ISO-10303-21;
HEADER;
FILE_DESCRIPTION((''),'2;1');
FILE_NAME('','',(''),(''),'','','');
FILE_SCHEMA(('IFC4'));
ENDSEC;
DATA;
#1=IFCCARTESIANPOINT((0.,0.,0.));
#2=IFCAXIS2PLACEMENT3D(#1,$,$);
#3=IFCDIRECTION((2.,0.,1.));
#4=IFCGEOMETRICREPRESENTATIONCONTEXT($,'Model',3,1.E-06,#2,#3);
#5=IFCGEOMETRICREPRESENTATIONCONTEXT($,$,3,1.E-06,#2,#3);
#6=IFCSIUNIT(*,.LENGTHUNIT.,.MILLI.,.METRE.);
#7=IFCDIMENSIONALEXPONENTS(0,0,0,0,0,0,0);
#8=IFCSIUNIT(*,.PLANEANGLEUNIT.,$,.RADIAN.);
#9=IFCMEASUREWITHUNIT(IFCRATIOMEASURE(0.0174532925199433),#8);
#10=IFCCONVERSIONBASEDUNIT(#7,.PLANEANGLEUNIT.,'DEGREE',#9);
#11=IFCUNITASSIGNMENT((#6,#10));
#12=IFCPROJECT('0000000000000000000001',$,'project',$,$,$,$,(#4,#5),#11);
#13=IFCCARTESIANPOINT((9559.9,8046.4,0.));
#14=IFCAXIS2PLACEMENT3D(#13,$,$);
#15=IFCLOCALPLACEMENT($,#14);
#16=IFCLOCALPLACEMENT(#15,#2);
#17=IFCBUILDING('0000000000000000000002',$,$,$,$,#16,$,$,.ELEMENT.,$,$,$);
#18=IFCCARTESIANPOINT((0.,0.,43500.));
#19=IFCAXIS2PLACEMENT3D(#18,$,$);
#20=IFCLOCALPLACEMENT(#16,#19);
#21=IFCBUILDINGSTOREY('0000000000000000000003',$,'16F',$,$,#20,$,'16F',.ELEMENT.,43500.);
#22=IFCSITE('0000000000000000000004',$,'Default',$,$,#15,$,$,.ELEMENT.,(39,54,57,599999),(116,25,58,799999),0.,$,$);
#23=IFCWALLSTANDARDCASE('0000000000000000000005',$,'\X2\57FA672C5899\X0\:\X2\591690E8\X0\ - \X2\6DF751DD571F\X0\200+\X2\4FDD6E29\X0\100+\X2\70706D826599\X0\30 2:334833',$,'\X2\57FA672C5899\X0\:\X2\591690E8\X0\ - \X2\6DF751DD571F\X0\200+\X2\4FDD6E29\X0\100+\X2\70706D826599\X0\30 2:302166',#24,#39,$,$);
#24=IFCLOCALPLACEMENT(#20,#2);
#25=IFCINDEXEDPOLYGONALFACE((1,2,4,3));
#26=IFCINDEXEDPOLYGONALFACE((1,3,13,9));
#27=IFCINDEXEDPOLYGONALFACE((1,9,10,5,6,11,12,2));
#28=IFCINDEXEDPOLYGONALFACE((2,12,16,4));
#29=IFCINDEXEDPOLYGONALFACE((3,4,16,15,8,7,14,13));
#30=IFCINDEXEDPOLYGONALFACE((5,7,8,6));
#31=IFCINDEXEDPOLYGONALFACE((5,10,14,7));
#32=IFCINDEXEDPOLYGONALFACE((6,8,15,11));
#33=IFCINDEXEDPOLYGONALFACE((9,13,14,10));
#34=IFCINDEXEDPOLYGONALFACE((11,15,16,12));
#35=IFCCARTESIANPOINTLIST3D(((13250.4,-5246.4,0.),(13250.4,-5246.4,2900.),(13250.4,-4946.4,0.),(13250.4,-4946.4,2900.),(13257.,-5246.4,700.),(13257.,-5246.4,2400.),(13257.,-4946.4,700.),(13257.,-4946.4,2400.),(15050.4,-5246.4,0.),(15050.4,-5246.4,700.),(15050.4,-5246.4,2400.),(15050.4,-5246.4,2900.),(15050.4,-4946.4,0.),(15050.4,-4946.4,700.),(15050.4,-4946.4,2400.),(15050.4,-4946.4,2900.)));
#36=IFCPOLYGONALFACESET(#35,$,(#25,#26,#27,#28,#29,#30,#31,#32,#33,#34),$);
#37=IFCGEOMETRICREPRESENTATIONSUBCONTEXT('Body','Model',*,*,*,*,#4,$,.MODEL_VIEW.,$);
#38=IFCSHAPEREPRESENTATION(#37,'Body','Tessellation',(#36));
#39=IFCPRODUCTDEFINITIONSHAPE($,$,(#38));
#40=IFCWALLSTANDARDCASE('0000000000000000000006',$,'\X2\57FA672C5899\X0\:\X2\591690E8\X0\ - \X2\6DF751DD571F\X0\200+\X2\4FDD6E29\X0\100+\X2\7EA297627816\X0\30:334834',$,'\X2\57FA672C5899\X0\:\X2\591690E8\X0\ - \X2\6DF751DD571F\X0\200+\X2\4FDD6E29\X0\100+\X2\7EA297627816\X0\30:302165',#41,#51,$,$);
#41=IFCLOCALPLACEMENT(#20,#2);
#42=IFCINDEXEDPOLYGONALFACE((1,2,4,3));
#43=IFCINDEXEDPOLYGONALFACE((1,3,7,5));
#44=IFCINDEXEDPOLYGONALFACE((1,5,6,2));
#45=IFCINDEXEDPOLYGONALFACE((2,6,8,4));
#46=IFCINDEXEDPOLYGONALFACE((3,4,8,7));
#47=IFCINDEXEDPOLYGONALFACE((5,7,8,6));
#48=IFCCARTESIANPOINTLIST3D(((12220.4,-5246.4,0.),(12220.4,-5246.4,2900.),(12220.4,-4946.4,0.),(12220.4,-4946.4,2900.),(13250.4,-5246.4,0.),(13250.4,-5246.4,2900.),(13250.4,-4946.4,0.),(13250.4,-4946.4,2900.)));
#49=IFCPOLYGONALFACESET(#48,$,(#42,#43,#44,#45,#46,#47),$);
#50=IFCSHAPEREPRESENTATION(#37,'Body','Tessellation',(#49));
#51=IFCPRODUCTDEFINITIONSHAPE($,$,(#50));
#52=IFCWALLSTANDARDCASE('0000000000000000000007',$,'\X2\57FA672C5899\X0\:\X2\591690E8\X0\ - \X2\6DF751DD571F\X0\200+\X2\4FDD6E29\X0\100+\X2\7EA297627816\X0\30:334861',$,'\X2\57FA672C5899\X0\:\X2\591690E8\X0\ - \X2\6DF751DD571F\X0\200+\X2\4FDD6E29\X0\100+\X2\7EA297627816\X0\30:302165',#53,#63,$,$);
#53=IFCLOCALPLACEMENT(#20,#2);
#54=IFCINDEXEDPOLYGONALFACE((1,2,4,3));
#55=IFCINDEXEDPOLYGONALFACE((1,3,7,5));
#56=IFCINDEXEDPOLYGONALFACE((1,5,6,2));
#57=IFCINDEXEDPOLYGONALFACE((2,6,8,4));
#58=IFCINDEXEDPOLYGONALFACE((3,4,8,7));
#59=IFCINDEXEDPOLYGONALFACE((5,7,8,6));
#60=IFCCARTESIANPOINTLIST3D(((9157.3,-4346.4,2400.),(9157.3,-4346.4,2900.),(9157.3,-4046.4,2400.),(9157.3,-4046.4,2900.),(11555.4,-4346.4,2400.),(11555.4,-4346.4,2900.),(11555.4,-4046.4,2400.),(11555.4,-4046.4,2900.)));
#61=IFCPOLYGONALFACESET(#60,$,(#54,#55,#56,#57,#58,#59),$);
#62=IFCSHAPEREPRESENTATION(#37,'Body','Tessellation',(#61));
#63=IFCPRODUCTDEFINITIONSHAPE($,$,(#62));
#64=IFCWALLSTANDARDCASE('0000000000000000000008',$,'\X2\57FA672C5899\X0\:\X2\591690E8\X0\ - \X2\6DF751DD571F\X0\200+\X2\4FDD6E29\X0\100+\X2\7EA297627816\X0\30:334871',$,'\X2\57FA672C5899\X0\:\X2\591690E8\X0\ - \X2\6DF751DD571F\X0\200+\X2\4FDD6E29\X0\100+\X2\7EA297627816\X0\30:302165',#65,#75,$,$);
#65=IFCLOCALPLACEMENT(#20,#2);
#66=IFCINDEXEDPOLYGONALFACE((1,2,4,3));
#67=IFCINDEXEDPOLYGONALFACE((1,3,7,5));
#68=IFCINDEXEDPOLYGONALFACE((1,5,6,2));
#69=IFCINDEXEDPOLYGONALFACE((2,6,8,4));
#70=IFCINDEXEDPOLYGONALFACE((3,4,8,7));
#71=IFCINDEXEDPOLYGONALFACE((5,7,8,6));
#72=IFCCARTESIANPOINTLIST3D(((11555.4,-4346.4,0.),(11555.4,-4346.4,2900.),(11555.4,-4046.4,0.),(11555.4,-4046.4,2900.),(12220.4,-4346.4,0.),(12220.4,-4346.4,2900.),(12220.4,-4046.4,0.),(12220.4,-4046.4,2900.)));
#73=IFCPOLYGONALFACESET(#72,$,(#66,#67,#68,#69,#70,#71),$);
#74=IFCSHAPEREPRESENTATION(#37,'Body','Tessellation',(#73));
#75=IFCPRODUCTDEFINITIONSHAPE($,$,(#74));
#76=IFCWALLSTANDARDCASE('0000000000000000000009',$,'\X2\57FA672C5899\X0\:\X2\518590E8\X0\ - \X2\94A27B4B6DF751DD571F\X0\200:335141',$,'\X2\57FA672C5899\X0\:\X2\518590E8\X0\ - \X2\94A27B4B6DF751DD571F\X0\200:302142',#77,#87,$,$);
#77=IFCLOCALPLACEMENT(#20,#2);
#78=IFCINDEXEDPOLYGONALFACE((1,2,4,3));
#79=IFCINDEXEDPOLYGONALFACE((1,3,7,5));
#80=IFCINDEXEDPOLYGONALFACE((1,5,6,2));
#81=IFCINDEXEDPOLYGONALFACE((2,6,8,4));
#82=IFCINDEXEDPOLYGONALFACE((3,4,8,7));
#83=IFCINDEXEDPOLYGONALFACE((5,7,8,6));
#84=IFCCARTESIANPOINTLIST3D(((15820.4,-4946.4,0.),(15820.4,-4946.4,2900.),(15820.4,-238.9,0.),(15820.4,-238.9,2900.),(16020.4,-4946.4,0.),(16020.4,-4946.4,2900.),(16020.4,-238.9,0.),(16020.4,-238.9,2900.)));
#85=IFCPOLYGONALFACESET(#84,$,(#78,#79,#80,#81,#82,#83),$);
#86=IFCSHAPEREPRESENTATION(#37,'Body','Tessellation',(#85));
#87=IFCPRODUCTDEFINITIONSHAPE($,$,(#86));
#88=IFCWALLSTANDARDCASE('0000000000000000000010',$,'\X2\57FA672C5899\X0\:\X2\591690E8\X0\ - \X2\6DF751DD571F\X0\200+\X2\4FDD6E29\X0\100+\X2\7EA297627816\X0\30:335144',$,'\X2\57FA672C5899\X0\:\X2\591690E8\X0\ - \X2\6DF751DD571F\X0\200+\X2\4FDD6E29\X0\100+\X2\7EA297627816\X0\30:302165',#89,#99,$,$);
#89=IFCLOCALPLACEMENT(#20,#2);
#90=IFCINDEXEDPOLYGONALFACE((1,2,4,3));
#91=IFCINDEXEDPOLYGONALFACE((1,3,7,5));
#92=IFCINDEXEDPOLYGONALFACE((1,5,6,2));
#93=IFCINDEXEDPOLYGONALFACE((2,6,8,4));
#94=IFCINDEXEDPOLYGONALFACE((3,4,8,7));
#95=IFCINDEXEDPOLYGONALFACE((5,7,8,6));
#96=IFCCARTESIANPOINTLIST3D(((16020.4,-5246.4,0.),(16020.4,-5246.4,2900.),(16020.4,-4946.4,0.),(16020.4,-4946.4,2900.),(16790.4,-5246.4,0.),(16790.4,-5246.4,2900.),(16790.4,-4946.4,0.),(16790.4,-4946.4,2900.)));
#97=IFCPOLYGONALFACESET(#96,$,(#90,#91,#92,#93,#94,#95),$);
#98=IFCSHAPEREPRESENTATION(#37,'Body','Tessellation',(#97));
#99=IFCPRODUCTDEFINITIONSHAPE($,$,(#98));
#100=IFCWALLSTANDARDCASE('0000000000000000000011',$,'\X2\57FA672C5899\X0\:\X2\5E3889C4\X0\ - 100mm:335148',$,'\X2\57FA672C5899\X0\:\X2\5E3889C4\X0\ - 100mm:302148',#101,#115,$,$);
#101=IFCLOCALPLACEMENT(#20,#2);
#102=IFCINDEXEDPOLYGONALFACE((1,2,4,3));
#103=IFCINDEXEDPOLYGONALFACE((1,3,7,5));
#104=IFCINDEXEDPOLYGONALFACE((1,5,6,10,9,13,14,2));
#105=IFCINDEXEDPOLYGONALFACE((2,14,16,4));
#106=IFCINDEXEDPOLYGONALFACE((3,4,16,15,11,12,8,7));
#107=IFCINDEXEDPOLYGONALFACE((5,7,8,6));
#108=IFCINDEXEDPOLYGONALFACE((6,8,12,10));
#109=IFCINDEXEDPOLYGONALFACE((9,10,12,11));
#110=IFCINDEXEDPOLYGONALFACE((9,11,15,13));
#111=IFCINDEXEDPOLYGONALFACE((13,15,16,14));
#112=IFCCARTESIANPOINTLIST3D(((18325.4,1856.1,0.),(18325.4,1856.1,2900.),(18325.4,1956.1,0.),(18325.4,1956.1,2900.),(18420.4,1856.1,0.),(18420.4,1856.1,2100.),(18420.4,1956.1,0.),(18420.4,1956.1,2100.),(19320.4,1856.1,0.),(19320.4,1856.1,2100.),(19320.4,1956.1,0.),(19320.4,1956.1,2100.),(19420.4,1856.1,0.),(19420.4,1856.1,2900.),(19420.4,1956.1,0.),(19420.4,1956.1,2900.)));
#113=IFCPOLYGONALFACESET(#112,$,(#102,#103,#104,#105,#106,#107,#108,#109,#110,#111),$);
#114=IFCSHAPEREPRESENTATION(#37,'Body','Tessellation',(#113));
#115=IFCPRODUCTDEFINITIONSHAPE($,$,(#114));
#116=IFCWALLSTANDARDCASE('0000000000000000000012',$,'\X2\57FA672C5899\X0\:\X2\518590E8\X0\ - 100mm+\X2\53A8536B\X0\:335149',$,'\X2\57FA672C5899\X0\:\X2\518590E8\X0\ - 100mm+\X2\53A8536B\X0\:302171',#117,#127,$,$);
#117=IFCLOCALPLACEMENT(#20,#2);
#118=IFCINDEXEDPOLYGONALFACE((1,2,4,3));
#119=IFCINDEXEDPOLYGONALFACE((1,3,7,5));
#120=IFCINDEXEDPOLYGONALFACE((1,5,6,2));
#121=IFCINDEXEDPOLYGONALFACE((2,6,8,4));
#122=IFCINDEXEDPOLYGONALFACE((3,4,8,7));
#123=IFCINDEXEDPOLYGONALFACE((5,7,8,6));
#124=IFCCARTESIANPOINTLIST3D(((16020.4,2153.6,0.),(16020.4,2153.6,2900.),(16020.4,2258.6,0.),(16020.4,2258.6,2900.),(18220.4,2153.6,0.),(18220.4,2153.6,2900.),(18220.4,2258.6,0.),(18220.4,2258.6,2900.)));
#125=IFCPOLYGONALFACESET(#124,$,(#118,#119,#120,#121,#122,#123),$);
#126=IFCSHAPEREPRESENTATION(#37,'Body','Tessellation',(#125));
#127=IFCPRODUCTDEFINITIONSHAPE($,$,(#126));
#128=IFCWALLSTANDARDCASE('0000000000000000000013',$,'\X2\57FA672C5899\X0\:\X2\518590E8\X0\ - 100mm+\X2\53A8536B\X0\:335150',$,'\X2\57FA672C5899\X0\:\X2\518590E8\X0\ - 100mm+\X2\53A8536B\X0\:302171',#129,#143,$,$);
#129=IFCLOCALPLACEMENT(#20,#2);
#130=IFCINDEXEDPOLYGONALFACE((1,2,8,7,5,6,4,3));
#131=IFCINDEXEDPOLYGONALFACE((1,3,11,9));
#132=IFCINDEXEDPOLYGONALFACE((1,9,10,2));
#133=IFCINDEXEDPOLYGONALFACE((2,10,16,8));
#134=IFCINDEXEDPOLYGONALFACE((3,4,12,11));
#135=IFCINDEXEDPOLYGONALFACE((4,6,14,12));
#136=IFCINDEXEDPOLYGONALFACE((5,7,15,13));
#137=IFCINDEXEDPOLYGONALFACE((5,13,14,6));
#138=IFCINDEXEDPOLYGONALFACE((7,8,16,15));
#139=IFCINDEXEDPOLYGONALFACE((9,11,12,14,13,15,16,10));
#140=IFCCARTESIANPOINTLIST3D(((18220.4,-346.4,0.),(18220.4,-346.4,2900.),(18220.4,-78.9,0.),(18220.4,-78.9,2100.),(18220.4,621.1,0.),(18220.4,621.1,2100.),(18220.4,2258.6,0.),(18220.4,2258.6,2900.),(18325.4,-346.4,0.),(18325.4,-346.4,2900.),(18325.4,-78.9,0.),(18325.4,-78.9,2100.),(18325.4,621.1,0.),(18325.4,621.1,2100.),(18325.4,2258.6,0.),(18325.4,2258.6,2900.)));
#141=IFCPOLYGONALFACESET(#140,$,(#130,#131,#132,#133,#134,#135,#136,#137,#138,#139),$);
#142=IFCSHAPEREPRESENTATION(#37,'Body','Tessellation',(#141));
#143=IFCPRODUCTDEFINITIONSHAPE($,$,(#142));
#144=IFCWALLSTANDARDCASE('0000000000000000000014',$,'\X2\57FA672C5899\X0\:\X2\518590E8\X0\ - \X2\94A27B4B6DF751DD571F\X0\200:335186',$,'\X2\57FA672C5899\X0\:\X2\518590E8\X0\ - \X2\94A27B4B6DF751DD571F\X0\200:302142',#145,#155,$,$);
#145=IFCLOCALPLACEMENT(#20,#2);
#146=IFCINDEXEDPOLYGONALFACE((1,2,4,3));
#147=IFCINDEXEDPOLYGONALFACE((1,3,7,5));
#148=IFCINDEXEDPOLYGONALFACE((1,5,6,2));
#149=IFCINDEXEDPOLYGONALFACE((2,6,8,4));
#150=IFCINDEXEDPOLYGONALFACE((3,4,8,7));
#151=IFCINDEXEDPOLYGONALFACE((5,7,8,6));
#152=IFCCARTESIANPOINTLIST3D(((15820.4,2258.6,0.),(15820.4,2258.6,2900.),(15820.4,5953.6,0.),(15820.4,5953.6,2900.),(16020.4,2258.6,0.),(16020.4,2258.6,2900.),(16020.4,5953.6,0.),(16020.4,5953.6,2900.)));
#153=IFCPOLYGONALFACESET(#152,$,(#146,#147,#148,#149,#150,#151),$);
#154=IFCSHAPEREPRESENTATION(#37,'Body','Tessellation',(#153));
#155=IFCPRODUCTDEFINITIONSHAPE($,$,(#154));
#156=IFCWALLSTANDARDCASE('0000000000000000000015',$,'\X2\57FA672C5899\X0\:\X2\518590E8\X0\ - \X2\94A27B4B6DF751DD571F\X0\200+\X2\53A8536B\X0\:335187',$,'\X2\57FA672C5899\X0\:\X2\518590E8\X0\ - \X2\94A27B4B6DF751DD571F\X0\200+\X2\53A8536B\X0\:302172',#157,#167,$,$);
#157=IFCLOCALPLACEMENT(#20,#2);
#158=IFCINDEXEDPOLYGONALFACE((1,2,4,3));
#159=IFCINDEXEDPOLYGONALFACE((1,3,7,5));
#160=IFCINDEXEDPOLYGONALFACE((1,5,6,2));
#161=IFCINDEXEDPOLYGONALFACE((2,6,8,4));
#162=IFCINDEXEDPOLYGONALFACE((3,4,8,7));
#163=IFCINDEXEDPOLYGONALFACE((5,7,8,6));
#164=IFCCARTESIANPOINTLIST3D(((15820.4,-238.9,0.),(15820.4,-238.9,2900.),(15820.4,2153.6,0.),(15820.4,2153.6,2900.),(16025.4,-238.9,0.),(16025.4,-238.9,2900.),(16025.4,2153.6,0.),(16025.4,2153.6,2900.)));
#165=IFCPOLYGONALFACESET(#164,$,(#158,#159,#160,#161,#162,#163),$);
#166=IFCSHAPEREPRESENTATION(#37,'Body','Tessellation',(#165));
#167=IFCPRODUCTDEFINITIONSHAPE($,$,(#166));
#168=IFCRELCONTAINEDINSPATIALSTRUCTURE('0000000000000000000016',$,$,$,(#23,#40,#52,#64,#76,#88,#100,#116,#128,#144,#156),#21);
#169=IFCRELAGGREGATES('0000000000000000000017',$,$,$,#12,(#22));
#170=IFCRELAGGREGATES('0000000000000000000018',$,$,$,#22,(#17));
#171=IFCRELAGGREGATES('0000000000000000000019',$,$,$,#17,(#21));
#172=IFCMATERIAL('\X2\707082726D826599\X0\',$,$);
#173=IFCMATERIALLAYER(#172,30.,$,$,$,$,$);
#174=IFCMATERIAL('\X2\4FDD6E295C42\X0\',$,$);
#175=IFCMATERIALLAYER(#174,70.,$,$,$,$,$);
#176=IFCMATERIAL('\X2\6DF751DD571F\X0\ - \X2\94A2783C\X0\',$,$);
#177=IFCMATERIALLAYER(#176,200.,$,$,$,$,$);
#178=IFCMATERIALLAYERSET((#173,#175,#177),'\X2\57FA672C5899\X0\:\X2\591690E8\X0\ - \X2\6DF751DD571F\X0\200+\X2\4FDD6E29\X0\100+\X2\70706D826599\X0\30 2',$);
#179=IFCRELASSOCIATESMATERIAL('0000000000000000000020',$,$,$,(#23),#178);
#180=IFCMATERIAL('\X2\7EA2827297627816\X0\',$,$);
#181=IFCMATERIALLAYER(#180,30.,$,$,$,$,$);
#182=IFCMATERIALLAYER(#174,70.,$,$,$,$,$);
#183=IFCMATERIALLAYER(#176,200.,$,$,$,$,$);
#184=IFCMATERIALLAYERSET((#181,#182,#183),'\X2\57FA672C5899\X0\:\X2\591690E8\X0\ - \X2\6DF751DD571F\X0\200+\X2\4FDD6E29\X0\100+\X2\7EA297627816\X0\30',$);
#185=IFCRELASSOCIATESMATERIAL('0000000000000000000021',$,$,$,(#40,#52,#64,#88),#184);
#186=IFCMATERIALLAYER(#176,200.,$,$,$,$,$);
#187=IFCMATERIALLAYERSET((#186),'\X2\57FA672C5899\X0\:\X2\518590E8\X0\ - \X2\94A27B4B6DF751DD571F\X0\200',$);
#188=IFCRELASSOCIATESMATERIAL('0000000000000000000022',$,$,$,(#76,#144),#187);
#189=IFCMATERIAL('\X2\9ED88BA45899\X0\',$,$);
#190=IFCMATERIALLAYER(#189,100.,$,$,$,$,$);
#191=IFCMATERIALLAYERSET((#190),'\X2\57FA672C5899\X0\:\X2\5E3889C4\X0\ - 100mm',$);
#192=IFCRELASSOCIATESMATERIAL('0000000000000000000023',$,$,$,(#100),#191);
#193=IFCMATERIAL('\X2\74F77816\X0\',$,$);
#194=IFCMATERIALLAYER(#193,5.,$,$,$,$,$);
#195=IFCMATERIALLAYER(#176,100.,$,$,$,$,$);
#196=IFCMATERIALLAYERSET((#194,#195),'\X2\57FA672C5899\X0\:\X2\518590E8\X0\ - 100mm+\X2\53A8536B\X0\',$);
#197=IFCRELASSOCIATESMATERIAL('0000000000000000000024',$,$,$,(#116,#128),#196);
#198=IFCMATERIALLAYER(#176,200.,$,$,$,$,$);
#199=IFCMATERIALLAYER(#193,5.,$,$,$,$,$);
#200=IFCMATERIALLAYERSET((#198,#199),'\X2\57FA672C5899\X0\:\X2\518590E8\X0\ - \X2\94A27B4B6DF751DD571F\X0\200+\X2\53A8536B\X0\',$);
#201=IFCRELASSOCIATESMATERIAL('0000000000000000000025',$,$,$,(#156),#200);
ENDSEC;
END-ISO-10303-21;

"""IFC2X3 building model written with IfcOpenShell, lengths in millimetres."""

from ifc_helpers import new_model, entity, si_unit, converted_unit, direction, frame, frame_2d, origin, place, context, subcontext, project, spatial, rectangle, extrude, material, layer, layer_set, layer_usage, element, save


model = new_model("IFC2X3")

# Units and contexts
model_context = context("Model", 3, precision=1e-06, world=origin(), true_north=direction((2.0, 0.0, 1.0)))
context_of_model = context(None, 3, precision=1e-06, world=origin(), true_north=direction((2.0, 0.0, 1.0)))
body_context = subcontext(model_context, "Body", "Model", "MODEL_VIEW")
ifc_project = project(units=[si_unit("LENGTHUNIT", "METRE", prefix="MILLI"), converted_unit("PLANEANGLEUNIT", "DEGREE", entity("IfcRatioMeasure", 0.0174532925199433), si_unit("PLANEANGLEUNIT", "RADIAN"), dimensions=[0, 0, 0, 0, 0, 0, 0])], contexts=[model_context, context_of_model])

# Site, building, storey
site_placement = place(None, frame((9559.9, 8046.4, 0.0)))
site = spatial("IfcSite", under=ifc_project, at=site_placement, Name="Default", CompositionType="ELEMENT", RefLatitude=(39, 54, 57, 599999), RefLongitude=(116, 25, 58, 799999), RefElevation=0.0)
building_placement = place(site_placement, origin())
building = spatial("IfcBuilding", under=site, at=building_placement, CompositionType="ELEMENT")
storey_placement = place(building_placement, frame((0.0, 0.0, 43500.0)))
storey = spatial("IfcBuildingStorey", under=building, at=storey_placement, Name="16F", LongName="16F", CompositionType="ELEMENT", Elevation=43500.0)

# Shared definitions
ifc_material_1 = material(Name="混凝土 - 钢砼")
ifc_layer_1 = layer(ifc_material_1, 200.0)
ifc_layer_set_1 = layer_set([ifc_layer_1], Name="基本墙:内部 - 钢筋混凝土200")
ifc_material_2 = material(Name="红色面砖")
ifc_layer_2 = layer(ifc_material_2, 30.0)
ifc_material_3 = material(Name="保温层")
ifc_layer_3 = layer(ifc_material_3, 70.0)
ifc_layer_4 = layer(ifc_material_1, 200.0)
ifc_layer_set_2 = layer_set([ifc_layer_2, ifc_layer_3, ifc_layer_4], Name="基本墙:外部 - 混凝土200+保温100+红面砖30")

# Shared definitions
ifc_material_4 = material(Name="默认墙")
ifc_layer_5 = layer(ifc_material_4, 100.0)
ifc_layer_set_3 = layer_set([ifc_layer_5], Name="基本墙:常规 - 100mm")

# Shared definitions
ifc_material_5 = material(Name="瓷砖")
ifc_layer_6 = layer(ifc_material_5, 5.0)
ifc_layer_7 = layer(ifc_material_1, 100.0)
ifc_layer_set_4 = layer_set([ifc_layer_6, ifc_layer_7], Name="基本墙:内部 - 100mm+厨卫")

# Shared definitions
ifc_layer_8 = layer(ifc_material_1, 200.0)
ifc_layer_9 = layer(ifc_material_5, 5.0)
ifc_layer_set_5 = layer_set([ifc_layer_8, ifc_layer_9], Name="基本墙:内部 - 钢筋混凝土200+厨卫")

# Wall, opening
ifc_material_6 = material(Name="灰色涂料")
ifc_layer_10 = layer(ifc_material_6, 30.0)
ifc_layer_11 = layer(ifc_material_3, 70.0)
ifc_layer_12 = layer(ifc_material_1, 200.0)
ifc_layer_set_6 = layer_set([ifc_layer_10, ifc_layer_11, ifc_layer_12], Name="基本墙:外部 - 混凝土200+保温100+灰涂料30 2")
ifc_layer_usage_1 = layer_usage(ifc_layer_set_6, "AXIS2", "NEGATIVE", 150.0)
wall_1_placement = place(storey_placement, frame((15050.4, -5096.4, 0.0), z_axis=(0.0, 0.0, 1.0), x_axis=(-1.0, 0.0, 0.0)))
wall_1 = element("IfcWallStandardCase", 1, at=wall_1_placement, inside=storey, material=ifc_layer_usage_1, Name="基本墙:外部 - 混凝土200+保温100+灰涂料30 2:334833", ObjectType="基本墙:外部 - 混凝土200+保温100+灰涂料30 2:302166", context=body_context, shape_type="SweptSolid", body=[
    extrude(rectangle(XDim=1800.0, YDim=300.0, at=frame_2d((900.0, 0.0), x_axis=(-1.0, 0.0))), origin(), (0.0, 0.0, 1.0), 2900.0),
])
opening_1_placement = place(wall_1_placement, frame((-6.6, -150.0, 700.0)))
element("IfcOpeningElement", 2, at=opening_1_placement, cuts=wall_1, ObjectType="Opening", context=body_context, shape_type="SweptSolid", body=[
    extrude(rectangle(XDim=1700.0, YDim=1800.0, at=frame_2d((850.0, 900.0), x_axis=(1.0, 0.0))), frame((0.0, 0.0, 0.0), z_axis=(0.0, 1.0, 0.0), x_axis=(0.0, 0.0, 1.0)), (0.0, 0.0, 1.0), 300.0),
])

# Walls
ifc_layer_usage_2 = layer_usage(ifc_layer_set_2, "AXIS2", "NEGATIVE", 150.0)
wall_2_placement = place(storey_placement, frame((13250.4, -5096.4, 0.0), z_axis=(0.0, 0.0, 1.0), x_axis=(-1.0, 0.0, 0.0)))
element("IfcWallStandardCase", 3, at=wall_2_placement, inside=storey, material=ifc_layer_usage_2, Name="基本墙:外部 - 混凝土200+保温100+红面砖30:334834", ObjectType="基本墙:外部 - 混凝土200+保温100+红面砖30:302165", context=body_context, shape_type="SweptSolid", body=[
    extrude(rectangle(XDim=1030.0, YDim=300.0, at=frame_2d((515.0, 0.0), x_axis=(-1.0, 0.0))), origin(), (0.0, 0.0, 1.0), 2900.0),
])
ifc_layer_usage_3 = layer_usage(ifc_layer_set_2, "AXIS2", "NEGATIVE", 150.0)
wall_3_placement = place(storey_placement, frame((11555.4, -4196.4, 2400.0), z_axis=(0.0, 0.0, 1.0), x_axis=(-1.0, 0.0, 0.0)))
element("IfcWallStandardCase", 4, at=wall_3_placement, inside=storey, material=ifc_layer_usage_3, Name="基本墙:外部 - 混凝土200+保温100+红面砖30:334861", ObjectType="基本墙:外部 - 混凝土200+保温100+红面砖30:302165", context=body_context, shape_type="SweptSolid", body=[
    extrude(rectangle(XDim=2398.1, YDim=300.0, at=frame_2d((1199.0, 0.0), x_axis=(-1.0, 0.0))), origin(), (0.0, 0.0, 1.0), 500.0),
])

# Walls
ifc_layer_usage_4 = layer_usage(ifc_layer_set_2, "AXIS2", "NEGATIVE", 150.0)
wall_4_placement = place(storey_placement, frame((12220.4, -4196.4, 0.0), z_axis=(0.0, 0.0, 1.0), x_axis=(-1.0, 0.0, 0.0)))
element("IfcWallStandardCase", 5, at=wall_4_placement, inside=storey, material=ifc_layer_usage_4, Name="基本墙:外部 - 混凝土200+保温100+红面砖30:334871", ObjectType="基本墙:外部 - 混凝土200+保温100+红面砖30:302165", context=body_context, shape_type="SweptSolid", body=[
    extrude(rectangle(XDim=665.0, YDim=300.0, at=frame_2d((332.5, 0.0), x_axis=(-1.0, 0.0))), origin(), (0.0, 0.0, 1.0), 2900.0),
])
ifc_layer_usage_5 = layer_usage(ifc_layer_set_1, "AXIS2", "NEGATIVE", 100.0)
wall_5_placement = place(storey_placement, frame((15920.4, -4946.4, 0.0), z_axis=(0.0, 0.0, 1.0), x_axis=(0.0, 1.0, 0.0)))
element("IfcWallStandardCase", 6, at=wall_5_placement, inside=storey, material=ifc_layer_usage_5, Name="基本墙:内部 - 钢筋混凝土200:335141", ObjectType="基本墙:内部 - 钢筋混凝土200:302142", context=body_context, shape_type="SweptSolid", body=[
    extrude(rectangle(XDim=4707.5, YDim=200.0, at=frame_2d((2353.8, 0.0), x_axis=(-1.0, 0.0))), origin(), (0.0, 0.0, 1.0), 2900.0),
])
ifc_layer_usage_6 = layer_usage(ifc_layer_set_2, "AXIS2", "POSITIVE", -150.0)
wall_6_placement = place(storey_placement, frame((16020.4, -5096.4, 0.0)))
element("IfcWallStandardCase", 7, at=wall_6_placement, inside=storey, material=ifc_layer_usage_6, Name="基本墙:外部 - 混凝土200+保温100+红面砖30:335144", ObjectType="基本墙:外部 - 混凝土200+保温100+红面砖30:302165", context=body_context, shape_type="SweptSolid", body=[
    extrude(rectangle(XDim=770.0, YDim=300.0, at=frame_2d((385.0, 0.0), x_axis=(-1.0, 0.0))), origin(), (0.0, 0.0, 1.0), 2900.0),
])

# Wall, opening
ifc_layer_usage_7 = layer_usage(ifc_layer_set_3, "AXIS2", "NEGATIVE", 50.0)
wall_7_placement = place(storey_placement, frame((18325.4, 1906.1, 0.0)))
wall_7 = element("IfcWallStandardCase", 8, at=wall_7_placement, inside=storey, material=ifc_layer_usage_7, Name="基本墙:常规 - 100mm:335148", ObjectType="基本墙:常规 - 100mm:302148", context=body_context, shape_type="SweptSolid", body=[
    extrude(rectangle(XDim=1095.0, YDim=100.0, at=frame_2d((547.5, 0.0), x_axis=(-1.0, 0.0))), origin(), (0.0, 0.0, 1.0), 2900.0),
])
opening_2_placement = place(wall_7_placement, frame((95.0, -50.0, 0.0)))
element("IfcOpeningElement", 9, at=opening_2_placement, cuts=wall_7, ObjectType="Opening", context=body_context, shape_type="SweptSolid", body=[
    extrude(rectangle(XDim=2100.0, YDim=900.0, at=frame_2d((1050.0, 450.0), x_axis=(1.0, 0.0))), frame((0.0, 0.0, 0.0), z_axis=(0.0, 1.0, 0.0), x_axis=(0.0, 0.0, 1.0)), (0.0, 0.0, 1.0), 100.0),
])

# Wall
ifc_layer_usage_8 = layer_usage(ifc_layer_set_4, "AXIS2", "POSITIVE", -52.5)
wall_8_placement = place(storey_placement, frame((16020.4, 2206.1, 0.0)))
element("IfcWallStandardCase", 10, at=wall_8_placement, inside=storey, material=ifc_layer_usage_8, Name="基本墙:内部 - 100mm+厨卫:335149", ObjectType="基本墙:内部 - 100mm+厨卫:302171", context=body_context, shape_type="SweptSolid", body=[
    extrude(rectangle(XDim=2200.0, YDim=105.0, at=frame_2d((1100.0, 0.0), x_axis=(-1.0, 0.0))), origin(), (0.0, 0.0, 1.0), 2900.0),
])

# Wall, opening
ifc_layer_usage_9 = layer_usage(ifc_layer_set_4, "AXIS2", "POSITIVE", -52.5)
wall_9_placement = place(storey_placement, frame((18272.9, 2258.6, 0.0), z_axis=(0.0, 0.0, 1.0), x_axis=(0.0, -1.0, 0.0)))
wall_9 = element("IfcWallStandardCase", 11, at=wall_9_placement, inside=storey, material=ifc_layer_usage_9, Name="基本墙:内部 - 100mm+厨卫:335150", ObjectType="基本墙:内部 - 100mm+厨卫:302171", context=body_context, shape_type="SweptSolid", body=[
    extrude(rectangle(XDim=2605.0, YDim=105.0, at=frame_2d((1302.5, 0.0), x_axis=(-1.0, 0.0))), origin(), (0.0, 0.0, 1.0), 2900.0),
])
opening_3_placement = place(wall_9_placement, frame((2337.5, 52.5, 0.0)))
element("IfcOpeningElement", 12, at=opening_3_placement, cuts=wall_9, ObjectType="Opening", context=body_context, shape_type="SweptSolid", body=[
    extrude(rectangle(XDim=2100.0, YDim=700.0, at=frame_2d((1050.0, 350.0), x_axis=(1.0, 0.0))), frame((0.0, 0.0, 0.0), z_axis=(0.0, -1.0, 0.0), x_axis=(0.0, 0.0, 1.0)), (0.0, 0.0, 1.0), 105.0),
])

# Walls
ifc_layer_usage_10 = layer_usage(ifc_layer_set_1, "AXIS2", "NEGATIVE", 100.0)
wall_10_placement = place(storey_placement, frame((15920.4, 2258.6, 0.0), z_axis=(0.0, 0.0, 1.0), x_axis=(0.0, 1.0, 0.0)))
element("IfcWallStandardCase", 13, at=wall_10_placement, inside=storey, material=ifc_layer_usage_10, Name="基本墙:内部 - 钢筋混凝土200:335186", ObjectType="基本墙:内部 - 钢筋混凝土200:302142", context=body_context, shape_type="SweptSolid", body=[
    extrude(rectangle(XDim=3695.0, YDim=200.0, at=frame_2d((1847.5, 0.0), x_axis=(-1.0, 0.0))), origin(), (0.0, 0.0, 1.0), 2900.0),
])
ifc_layer_usage_11 = layer_usage(ifc_layer_set_5, "AXIS2", "NEGATIVE", 102.5)
wall_11_placement = place(storey_placement, frame((15922.9, -238.9, 0.0), z_axis=(0.0, 0.0, 1.0), x_axis=(0.0, 1.0, 0.0)))
element("IfcWallStandardCase", 14, at=wall_11_placement, inside=storey, material=ifc_layer_usage_11, Name="基本墙:内部 - 钢筋混凝土200+厨卫:335187", ObjectType="基本墙:内部 - 钢筋混凝土200+厨卫:302172", context=body_context, shape_type="SweptSolid", body=[
    extrude(rectangle(XDim=2392.5, YDim=205.0, at=frame_2d((1196.2, 0.0), x_axis=(-1.0, 0.0))), origin(), (0.0, 0.0, 1.0), 2900.0),
])

save(model, "model.ifc")
